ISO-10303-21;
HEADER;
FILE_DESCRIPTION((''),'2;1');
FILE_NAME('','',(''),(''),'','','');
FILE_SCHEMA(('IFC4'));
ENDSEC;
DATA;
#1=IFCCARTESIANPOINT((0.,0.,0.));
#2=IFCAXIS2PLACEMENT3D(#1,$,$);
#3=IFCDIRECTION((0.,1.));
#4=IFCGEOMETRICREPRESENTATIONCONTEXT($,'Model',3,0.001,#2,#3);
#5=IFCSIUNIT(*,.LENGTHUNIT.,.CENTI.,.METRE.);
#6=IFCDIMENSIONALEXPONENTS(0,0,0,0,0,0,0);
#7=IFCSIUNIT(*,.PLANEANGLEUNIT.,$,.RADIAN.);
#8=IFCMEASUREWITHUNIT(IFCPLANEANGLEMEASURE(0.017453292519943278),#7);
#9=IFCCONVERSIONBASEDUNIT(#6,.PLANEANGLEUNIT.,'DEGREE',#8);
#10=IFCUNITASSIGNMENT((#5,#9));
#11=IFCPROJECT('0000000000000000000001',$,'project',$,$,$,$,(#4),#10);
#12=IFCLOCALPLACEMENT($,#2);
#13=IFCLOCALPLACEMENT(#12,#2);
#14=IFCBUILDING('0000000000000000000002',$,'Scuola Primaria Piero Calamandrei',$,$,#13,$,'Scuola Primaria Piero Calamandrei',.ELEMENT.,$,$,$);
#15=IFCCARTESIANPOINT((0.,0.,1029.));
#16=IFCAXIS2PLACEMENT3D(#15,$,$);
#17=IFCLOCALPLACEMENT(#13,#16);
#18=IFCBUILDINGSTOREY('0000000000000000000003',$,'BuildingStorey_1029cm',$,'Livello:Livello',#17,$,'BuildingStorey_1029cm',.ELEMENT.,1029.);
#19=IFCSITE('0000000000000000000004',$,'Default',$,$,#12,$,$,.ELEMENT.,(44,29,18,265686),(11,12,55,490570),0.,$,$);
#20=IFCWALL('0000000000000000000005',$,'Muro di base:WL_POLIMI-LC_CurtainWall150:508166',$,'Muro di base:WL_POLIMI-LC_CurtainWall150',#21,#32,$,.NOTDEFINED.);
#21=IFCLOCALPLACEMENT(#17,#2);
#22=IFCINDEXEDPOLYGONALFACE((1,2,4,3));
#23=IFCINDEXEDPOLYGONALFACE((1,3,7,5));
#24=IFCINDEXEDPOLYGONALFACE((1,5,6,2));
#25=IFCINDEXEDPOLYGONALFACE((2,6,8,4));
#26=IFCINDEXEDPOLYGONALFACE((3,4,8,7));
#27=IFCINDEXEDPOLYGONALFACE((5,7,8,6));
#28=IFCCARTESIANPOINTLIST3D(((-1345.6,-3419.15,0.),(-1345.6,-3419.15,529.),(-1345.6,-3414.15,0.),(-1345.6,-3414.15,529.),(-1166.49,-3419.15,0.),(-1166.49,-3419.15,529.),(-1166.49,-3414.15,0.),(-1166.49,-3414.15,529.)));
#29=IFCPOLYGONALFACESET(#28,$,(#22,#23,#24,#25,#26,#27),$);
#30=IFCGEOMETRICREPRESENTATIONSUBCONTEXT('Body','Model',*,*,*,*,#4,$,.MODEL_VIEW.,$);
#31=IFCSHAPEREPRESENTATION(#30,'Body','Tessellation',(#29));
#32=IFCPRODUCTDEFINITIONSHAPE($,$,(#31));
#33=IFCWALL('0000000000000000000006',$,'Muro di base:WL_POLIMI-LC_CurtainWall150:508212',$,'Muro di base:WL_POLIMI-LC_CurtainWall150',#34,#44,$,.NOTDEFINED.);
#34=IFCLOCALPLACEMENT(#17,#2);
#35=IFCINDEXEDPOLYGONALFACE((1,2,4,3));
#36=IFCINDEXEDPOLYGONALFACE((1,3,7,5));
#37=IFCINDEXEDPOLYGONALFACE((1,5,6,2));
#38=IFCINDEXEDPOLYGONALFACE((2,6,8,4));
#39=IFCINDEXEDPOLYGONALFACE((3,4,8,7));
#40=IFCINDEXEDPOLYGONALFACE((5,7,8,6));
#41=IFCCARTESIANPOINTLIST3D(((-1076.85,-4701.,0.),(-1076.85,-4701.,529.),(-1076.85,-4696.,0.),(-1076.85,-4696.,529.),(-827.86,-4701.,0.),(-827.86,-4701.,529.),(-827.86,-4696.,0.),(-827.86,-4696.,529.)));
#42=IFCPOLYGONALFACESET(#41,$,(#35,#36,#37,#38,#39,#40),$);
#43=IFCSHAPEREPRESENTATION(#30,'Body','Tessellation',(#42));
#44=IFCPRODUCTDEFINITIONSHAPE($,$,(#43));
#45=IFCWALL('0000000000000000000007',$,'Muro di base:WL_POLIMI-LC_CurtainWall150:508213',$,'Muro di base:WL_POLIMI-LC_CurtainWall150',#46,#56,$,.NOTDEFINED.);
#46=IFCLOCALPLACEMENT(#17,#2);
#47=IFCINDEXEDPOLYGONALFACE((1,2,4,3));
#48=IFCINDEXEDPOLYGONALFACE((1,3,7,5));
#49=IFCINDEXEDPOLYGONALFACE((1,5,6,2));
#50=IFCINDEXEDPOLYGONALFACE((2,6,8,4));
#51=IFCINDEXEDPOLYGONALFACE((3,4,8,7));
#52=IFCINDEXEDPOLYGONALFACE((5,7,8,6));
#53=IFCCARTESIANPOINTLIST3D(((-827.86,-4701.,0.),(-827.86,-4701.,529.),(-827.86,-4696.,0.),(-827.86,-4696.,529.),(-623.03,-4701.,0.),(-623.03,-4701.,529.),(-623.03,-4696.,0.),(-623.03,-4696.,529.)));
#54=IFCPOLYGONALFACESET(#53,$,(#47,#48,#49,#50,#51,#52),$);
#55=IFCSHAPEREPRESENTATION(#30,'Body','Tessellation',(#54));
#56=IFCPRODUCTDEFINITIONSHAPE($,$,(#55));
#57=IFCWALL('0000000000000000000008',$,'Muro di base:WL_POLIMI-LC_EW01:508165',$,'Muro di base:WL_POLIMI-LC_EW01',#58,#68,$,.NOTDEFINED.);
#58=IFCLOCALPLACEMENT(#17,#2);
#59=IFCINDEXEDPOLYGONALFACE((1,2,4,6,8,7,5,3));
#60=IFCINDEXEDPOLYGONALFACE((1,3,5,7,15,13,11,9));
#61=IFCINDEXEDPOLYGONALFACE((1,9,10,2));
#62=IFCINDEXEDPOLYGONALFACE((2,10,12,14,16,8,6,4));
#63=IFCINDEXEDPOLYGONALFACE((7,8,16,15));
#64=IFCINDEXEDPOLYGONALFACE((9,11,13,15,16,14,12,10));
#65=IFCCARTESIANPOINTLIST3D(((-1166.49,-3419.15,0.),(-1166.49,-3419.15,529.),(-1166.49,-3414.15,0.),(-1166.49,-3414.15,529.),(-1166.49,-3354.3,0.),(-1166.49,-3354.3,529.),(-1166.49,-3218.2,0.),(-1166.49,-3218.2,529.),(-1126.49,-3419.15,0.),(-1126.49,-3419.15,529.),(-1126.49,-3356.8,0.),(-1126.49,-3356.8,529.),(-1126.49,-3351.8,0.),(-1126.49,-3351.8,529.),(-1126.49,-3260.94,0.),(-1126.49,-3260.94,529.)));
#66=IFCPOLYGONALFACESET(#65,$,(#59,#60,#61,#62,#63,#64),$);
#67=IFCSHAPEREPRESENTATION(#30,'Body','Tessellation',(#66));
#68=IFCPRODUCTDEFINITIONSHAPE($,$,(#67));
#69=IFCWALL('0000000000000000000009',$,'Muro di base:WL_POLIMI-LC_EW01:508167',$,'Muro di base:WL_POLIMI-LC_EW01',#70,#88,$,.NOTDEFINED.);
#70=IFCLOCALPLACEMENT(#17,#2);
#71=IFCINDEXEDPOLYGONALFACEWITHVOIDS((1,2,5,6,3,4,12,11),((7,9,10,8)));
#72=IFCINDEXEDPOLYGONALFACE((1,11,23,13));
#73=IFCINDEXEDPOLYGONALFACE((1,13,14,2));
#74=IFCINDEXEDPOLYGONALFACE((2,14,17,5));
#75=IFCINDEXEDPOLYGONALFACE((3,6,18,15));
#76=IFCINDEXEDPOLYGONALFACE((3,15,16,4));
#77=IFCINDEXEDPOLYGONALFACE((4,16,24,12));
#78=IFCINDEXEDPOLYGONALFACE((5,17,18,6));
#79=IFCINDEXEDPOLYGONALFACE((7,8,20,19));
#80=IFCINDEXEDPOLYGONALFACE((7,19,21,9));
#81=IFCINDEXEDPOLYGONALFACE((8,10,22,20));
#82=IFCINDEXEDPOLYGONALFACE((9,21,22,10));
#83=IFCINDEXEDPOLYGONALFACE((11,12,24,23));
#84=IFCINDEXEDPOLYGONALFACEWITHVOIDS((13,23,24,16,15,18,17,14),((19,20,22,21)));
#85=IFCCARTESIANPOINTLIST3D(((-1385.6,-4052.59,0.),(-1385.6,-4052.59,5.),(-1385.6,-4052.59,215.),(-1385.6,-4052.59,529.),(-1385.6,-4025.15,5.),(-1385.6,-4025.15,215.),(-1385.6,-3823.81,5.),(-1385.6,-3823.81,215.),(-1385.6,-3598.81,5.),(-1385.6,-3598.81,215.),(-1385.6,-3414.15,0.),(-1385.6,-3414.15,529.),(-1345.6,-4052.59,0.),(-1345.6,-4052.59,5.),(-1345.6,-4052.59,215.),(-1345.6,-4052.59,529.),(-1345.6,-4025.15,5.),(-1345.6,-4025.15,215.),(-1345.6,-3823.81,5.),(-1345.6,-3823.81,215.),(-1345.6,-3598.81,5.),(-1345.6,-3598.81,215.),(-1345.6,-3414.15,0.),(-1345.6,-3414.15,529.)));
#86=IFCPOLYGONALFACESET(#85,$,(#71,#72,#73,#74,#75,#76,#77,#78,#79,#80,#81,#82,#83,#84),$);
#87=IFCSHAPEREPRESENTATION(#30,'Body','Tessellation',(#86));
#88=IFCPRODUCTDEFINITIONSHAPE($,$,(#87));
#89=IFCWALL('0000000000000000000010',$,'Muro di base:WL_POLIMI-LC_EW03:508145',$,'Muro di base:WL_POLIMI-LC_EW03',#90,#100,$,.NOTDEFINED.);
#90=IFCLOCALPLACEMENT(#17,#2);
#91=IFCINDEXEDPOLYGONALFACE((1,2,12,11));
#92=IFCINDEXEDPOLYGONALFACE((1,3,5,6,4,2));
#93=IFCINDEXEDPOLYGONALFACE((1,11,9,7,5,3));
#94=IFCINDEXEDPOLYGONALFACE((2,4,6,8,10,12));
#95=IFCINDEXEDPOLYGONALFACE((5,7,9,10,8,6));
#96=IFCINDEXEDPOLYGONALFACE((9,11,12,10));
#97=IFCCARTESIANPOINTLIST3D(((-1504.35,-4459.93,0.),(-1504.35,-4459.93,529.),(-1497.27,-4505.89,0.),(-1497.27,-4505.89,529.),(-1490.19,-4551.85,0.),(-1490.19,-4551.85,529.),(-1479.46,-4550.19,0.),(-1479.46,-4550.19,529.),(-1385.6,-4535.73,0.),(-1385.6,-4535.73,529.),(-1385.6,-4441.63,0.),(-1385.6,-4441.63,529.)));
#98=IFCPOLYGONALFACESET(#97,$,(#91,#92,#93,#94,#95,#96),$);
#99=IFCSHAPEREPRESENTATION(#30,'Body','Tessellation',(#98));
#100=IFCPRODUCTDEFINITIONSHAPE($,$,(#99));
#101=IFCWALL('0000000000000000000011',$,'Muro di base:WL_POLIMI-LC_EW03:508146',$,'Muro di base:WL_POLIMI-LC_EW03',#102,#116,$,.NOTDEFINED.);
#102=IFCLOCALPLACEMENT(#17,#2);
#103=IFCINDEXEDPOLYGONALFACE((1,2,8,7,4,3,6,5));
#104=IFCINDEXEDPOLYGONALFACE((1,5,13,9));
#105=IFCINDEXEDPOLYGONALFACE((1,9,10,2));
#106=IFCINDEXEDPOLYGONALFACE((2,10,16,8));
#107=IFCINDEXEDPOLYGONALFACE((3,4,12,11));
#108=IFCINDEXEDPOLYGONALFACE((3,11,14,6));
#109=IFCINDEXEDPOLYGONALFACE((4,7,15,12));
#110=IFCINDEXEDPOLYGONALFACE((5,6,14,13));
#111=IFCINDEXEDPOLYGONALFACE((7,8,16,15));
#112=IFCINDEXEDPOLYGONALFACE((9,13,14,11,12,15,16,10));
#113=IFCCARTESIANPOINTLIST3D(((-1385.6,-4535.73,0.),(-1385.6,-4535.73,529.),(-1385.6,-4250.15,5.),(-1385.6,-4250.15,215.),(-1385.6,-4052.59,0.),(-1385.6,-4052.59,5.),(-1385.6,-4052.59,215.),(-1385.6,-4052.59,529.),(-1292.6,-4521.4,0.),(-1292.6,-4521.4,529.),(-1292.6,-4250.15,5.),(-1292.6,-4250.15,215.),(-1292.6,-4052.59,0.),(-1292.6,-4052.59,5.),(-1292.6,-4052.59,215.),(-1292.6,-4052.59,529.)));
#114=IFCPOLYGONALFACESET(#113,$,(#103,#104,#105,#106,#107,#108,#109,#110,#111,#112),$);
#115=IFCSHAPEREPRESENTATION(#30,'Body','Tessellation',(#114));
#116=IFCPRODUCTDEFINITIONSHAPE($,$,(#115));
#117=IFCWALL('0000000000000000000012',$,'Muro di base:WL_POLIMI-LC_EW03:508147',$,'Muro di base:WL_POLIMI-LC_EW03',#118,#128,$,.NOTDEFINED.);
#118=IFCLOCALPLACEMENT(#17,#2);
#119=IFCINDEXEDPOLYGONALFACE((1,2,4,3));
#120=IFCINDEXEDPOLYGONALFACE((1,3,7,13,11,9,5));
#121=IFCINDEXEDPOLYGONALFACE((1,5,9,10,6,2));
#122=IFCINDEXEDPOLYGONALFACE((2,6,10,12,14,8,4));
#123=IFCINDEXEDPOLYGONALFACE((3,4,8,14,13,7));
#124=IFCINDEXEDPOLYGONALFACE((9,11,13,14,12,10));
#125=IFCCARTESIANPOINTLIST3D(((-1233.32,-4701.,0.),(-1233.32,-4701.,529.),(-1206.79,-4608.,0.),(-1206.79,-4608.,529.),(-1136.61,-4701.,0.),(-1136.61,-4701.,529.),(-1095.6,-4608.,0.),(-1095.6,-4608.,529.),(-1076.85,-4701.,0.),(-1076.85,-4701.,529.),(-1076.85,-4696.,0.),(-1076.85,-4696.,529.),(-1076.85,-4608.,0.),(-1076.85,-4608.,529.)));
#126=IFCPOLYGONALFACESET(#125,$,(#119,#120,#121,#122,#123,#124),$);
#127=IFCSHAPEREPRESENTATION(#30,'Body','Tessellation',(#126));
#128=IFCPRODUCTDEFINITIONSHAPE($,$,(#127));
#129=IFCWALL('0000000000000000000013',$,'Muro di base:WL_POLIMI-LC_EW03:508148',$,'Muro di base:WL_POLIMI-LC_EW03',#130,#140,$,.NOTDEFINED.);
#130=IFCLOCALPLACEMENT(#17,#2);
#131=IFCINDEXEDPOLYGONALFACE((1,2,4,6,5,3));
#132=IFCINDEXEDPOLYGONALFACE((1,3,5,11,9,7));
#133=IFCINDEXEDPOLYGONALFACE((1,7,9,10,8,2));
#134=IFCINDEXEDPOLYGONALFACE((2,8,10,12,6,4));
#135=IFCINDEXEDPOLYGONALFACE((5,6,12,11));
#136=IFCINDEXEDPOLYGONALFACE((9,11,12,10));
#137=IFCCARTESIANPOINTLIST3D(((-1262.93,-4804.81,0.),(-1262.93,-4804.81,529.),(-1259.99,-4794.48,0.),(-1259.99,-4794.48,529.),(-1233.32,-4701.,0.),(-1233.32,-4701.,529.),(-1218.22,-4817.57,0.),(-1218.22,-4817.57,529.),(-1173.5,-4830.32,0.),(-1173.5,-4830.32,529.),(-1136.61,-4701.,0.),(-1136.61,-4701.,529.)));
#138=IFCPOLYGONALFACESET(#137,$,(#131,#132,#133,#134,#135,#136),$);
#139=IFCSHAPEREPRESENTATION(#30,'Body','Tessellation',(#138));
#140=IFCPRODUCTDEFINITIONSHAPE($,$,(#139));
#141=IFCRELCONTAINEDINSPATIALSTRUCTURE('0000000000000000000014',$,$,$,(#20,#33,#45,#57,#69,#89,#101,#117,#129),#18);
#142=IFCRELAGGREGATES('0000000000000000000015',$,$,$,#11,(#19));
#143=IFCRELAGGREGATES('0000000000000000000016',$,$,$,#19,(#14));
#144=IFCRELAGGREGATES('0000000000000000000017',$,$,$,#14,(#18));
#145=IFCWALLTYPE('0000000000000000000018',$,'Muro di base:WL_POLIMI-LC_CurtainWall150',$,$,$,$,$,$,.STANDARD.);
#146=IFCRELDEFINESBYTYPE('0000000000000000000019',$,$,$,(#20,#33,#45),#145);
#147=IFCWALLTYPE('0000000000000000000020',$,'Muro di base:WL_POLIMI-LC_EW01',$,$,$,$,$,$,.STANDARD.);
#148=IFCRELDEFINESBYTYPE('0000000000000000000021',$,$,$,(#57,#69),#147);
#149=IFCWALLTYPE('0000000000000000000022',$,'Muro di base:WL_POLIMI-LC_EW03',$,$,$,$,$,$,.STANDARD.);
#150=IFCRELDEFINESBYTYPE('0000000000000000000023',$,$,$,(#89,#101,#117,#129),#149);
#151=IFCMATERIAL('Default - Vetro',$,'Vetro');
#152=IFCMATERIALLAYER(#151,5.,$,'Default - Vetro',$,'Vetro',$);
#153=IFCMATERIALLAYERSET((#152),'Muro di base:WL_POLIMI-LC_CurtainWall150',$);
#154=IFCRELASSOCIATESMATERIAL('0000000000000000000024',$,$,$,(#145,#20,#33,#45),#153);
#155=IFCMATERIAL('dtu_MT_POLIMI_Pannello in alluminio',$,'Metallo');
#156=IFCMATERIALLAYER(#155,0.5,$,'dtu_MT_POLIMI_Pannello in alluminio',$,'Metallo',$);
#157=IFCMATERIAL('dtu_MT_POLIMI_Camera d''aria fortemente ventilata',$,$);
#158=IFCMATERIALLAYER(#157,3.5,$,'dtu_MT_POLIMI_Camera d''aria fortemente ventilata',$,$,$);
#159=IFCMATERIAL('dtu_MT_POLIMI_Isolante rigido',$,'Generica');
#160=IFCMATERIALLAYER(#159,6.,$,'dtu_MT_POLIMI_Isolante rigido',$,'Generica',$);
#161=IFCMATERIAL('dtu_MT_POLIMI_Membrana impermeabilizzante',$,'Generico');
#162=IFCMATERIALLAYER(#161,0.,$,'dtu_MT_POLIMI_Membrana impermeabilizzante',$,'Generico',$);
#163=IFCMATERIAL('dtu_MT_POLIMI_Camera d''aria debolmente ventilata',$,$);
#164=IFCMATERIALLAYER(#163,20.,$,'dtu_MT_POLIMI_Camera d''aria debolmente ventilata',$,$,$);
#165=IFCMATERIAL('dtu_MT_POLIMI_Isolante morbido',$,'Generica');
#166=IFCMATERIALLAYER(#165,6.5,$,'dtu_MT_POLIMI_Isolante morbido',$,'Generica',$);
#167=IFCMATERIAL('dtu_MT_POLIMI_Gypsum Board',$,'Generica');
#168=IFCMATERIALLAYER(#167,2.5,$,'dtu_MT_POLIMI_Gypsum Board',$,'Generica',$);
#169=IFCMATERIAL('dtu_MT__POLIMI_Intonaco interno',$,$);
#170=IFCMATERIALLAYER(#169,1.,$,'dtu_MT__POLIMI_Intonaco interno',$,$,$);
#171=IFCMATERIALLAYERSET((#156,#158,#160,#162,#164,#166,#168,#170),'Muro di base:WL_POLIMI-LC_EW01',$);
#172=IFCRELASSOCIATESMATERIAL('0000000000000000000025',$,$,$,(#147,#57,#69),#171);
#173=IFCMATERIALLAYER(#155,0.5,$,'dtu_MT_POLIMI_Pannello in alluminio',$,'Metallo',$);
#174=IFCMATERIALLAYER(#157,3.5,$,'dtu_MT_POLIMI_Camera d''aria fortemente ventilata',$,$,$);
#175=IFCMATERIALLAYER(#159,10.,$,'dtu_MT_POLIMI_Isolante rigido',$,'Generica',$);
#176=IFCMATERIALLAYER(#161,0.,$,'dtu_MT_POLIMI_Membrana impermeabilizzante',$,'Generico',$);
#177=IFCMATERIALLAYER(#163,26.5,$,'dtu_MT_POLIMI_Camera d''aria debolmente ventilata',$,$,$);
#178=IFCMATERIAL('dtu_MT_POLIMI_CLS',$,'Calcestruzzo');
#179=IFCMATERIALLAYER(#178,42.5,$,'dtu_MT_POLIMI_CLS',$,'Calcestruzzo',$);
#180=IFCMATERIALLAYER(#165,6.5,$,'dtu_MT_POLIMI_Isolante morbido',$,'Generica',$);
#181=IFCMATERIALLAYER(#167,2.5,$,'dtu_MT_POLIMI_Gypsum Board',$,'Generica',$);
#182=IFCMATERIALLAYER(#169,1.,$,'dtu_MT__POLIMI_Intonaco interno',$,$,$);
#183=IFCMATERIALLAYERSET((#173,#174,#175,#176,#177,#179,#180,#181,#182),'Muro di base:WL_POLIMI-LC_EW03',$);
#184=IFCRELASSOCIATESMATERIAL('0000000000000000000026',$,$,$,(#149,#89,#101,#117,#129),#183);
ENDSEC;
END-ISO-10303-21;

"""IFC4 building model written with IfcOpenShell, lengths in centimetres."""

from ifc_helpers import new_model, entity, si_unit, converted_unit, direction, frame, frame_2d, origin, place, context, subcontext, project, spatial, polyline, rectangle, outline, extrude, material, layer, layer_set, layer_usage, type_object, element, save


model = new_model("IFC4")

# Units and contexts
model_context = context("Model", 3, precision=0.001, world=origin(), true_north=direction((0.0, 1.0)))
body_context = subcontext(model_context, "Body", "Model", "MODEL_VIEW")
ifc_project = project(units=[si_unit("LENGTHUNIT", "METRE", prefix="CENTI"), converted_unit("PLANEANGLEUNIT", "DEGREE", entity("IfcPlaneAngleMeasure", 0.017453292519943278), si_unit("PLANEANGLEUNIT", "RADIAN"), dimensions=[0, 0, 0, 0, 0, 0, 0])], contexts=[model_context])

# Site, building, storey
site_placement = place(None, origin())
site = spatial("IfcSite", under=ifc_project, at=site_placement, Name="Default", CompositionType="ELEMENT", RefLatitude=(44, 29, 18, 265686), RefLongitude=(11, 12, 55, 490570), RefElevation=0.0)
building_placement = place(site_placement, origin())
building = spatial("IfcBuilding", under=site, at=building_placement, Name="Scuola Primaria Piero Calamandrei", LongName="Scuola Primaria Piero Calamandrei", CompositionType="ELEMENT")
storey_placement = place(building_placement, frame((0.0, 0.0, 1029.0)))
storey = spatial("IfcBuildingStorey", under=building, at=storey_placement, Name="BuildingStorey_1029cm", ObjectType="Livello:Livello", LongName="BuildingStorey_1029cm", CompositionType="ELEMENT", Elevation=1029.0)

# Walls
ifc_material_1 = material(Name="Default - Vetro", Category="Vetro")
ifc_layer_1 = layer(ifc_material_1, 5.0, Name="Default - Vetro", Category="Vetro")
ifc_layer_set_1 = layer_set([ifc_layer_1], Name="Muro di base:WL_POLIMI-LC_CurtainWall150")
ifc_layer_usage_1 = layer_usage(ifc_layer_set_1, "AXIS2", "NEGATIVE", 2.5)
wall_type_1 = type_object("IfcWallType", Name="Muro di base:WL_POLIMI-LC_CurtainWall150", PredefinedType="STANDARD", material=ifc_layer_set_1)
wall_1_placement = place(storey_placement, frame((-1345.6, -3416.65, 0.0)))
element("IfcWall", 1, at=wall_1_placement, inside=storey, type_object=wall_type_1, material=ifc_layer_usage_1, Name="Muro di base:WL_POLIMI-LC_CurtainWall150:508166", ObjectType="Muro di base:WL_POLIMI-LC_CurtainWall150", PredefinedType="NOTDEFINED", context=body_context, shape_type="SweptSolid", body=[
    extrude(rectangle(XDim=179.11, YDim=5.0, at=frame_2d((89.56, 0.0), x_axis=(-1.0, 0.0))), origin(), (0.0, 0.0, 1.0), 529.0),
])
ifc_layer_usage_2 = layer_usage(ifc_layer_set_1, "AXIS2", "NEGATIVE", 2.5)
wall_2_placement = place(storey_placement, frame((-827.86, -4698.5, 0.0), z_axis=(0.0, 0.0, 1.0), x_axis=(-1.0, 0.0, 0.0)))
element("IfcWall", 2, at=wall_2_placement, inside=storey, type_object=wall_type_1, material=ifc_layer_usage_2, Name="Muro di base:WL_POLIMI-LC_CurtainWall150:508212", ObjectType="Muro di base:WL_POLIMI-LC_CurtainWall150", PredefinedType="NOTDEFINED", context=body_context, shape_type="SweptSolid", body=[
    extrude(rectangle(XDim=248.99, YDim=5.0, at=frame_2d((124.5, 0.0), x_axis=(-1.0, 0.0))), origin(), (0.0, 0.0, 1.0), 529.0),
])
ifc_layer_usage_3 = layer_usage(ifc_layer_set_1, "AXIS2", "NEGATIVE", 2.5)
wall_3_placement = place(storey_placement, frame((-623.03, -4698.5, 0.0), z_axis=(0.0, 0.0, 1.0), x_axis=(-1.0, 0.0, 0.0)))
element("IfcWall", 3, at=wall_3_placement, inside=storey, type_object=wall_type_1, material=ifc_layer_usage_3, Name="Muro di base:WL_POLIMI-LC_CurtainWall150:508213", ObjectType="Muro di base:WL_POLIMI-LC_CurtainWall150", PredefinedType="NOTDEFINED", context=body_context, shape_type="SweptSolid", body=[
    extrude(rectangle(XDim=204.83, YDim=5.0, at=frame_2d((102.41, 0.0), x_axis=(-1.0, 0.0))), origin(), (0.0, 0.0, 1.0), 529.0),
])
ifc_material_2 = material(Name="dtu_MT_POLIMI_Pannello in alluminio", Category="Metallo")
ifc_layer_2 = layer(ifc_material_2, 0.5, Name="dtu_MT_POLIMI_Pannello in alluminio", Category="Metallo")
ifc_material_3 = material(Name="dtu_MT_POLIMI_Camera d'aria fortemente ventilata")
ifc_layer_3 = layer(ifc_material_3, 3.5, Name="dtu_MT_POLIMI_Camera d'aria fortemente ventilata")
ifc_material_4 = material(Name="dtu_MT_POLIMI_Isolante rigido", Category="Generica")
ifc_layer_4 = layer(ifc_material_4, 6.0, Name="dtu_MT_POLIMI_Isolante rigido", Category="Generica")
ifc_material_5 = material(Name="dtu_MT_POLIMI_Membrana impermeabilizzante", Category="Generico")
ifc_layer_5 = layer(ifc_material_5, 0.0, Name="dtu_MT_POLIMI_Membrana impermeabilizzante", Category="Generico")
ifc_material_6 = material(Name="dtu_MT_POLIMI_Camera d'aria debolmente ventilata")
ifc_layer_6 = layer(ifc_material_6, 20.0, Name="dtu_MT_POLIMI_Camera d'aria debolmente ventilata")
ifc_material_7 = material(Name="dtu_MT_POLIMI_Isolante morbido", Category="Generica")
ifc_layer_7 = layer(ifc_material_7, 6.5, Name="dtu_MT_POLIMI_Isolante morbido", Category="Generica")
ifc_material_8 = material(Name="dtu_MT_POLIMI_Gypsum Board", Category="Generica")
ifc_layer_8 = layer(ifc_material_8, 2.5, Name="dtu_MT_POLIMI_Gypsum Board", Category="Generica")
ifc_material_9 = material(Name="dtu_MT__POLIMI_Intonaco interno")
ifc_layer_9 = layer(ifc_material_9, 1.0, Name="dtu_MT__POLIMI_Intonaco interno")
ifc_layer_set_2 = layer_set([ifc_layer_2, ifc_layer_3, ifc_layer_4, ifc_layer_5, ifc_layer_6, ifc_layer_7, ifc_layer_8, ifc_layer_9], Name="Muro di base:WL_POLIMI-LC_EW01")
ifc_layer_usage_4 = layer_usage(ifc_layer_set_2, "AXIS2", "NEGATIVE", 20.0)
wall_type_2 = type_object("IfcWallType", Name="Muro di base:WL_POLIMI-LC_EW01", PredefinedType="STANDARD", material=ifc_layer_set_2)
wall_4_placement = place(storey_placement, frame((-1146.49, -3419.15, 0.0), z_axis=(0.0, 0.0, 1.0), x_axis=(0.0, 1.0, 0.0)))
element("IfcWall", 4, at=wall_4_placement, inside=storey, type_object=wall_type_2, material=ifc_layer_usage_4, Name="Muro di base:WL_POLIMI-LC_EW01:508165", ObjectType="Muro di base:WL_POLIMI-LC_EW01", PredefinedType="NOTDEFINED", context=body_context, shape_type="SweptSolid", body=[
    extrude(outline(polyline([(158.21, -20.0), (200.95, 20.0), (64.85, 20.0), (5.0, 20.0), (0.0, 20.0), (0.0, -20.0), (62.35, -20.0), (67.35, -20.0), (158.21, -20.0)])), origin(), (0.0, 0.0, 1.0), 529.0),
])

# Wall, openings
ifc_layer_usage_5 = layer_usage(ifc_layer_set_2, "AXIS2", "NEGATIVE", 20.0)
wall_5_placement = place(storey_placement, frame((-1365.6, -4052.59, 0.0), z_axis=(0.0, 0.0, 1.0), x_axis=(0.0, 1.0, 0.0)))
wall_5 = element("IfcWall", 5, at=wall_5_placement, inside=storey, type_object=wall_type_2, material=ifc_layer_usage_5, Name="Muro di base:WL_POLIMI-LC_EW01:508167", ObjectType="Muro di base:WL_POLIMI-LC_EW01", PredefinedType="NOTDEFINED", context=body_context, shape_type="SweptSolid", body=[
    extrude(rectangle(XDim=638.44, YDim=40.0, at=frame_2d((319.22, 0.0), x_axis=(-1.0, 0.0))), origin(), (0.0, 0.0, 1.0), 529.0),
])
opening_1_placement = place(wall_5_placement, frame((-197.56, -20.0, 5.0)))
element("IfcOpeningElement", 6, at=opening_1_placement, cuts=wall_5, PredefinedType="OPENING", context=body_context, shape_type="SweptSolid", body=[
    extrude(rectangle(XDim=210.0, YDim=225.0, at=frame_2d((105.0, 112.5), x_axis=(-1.0, 0.0))), frame((0.0, 0.0, 0.0), z_axis=(0.0, 1.0, 0.0), x_axis=(0.0, 0.0, 1.0)), (0.0, 0.0, 1.0), 40.0),
])
opening_2_placement = place(wall_5_placement, frame((228.77, -20.0, 5.0)))
element("IfcOpeningElement", 7, at=opening_2_placement, cuts=wall_5, PredefinedType="OPENING", context=body_context, shape_type="SweptSolid", body=[
    extrude(rectangle(XDim=210.0, YDim=225.0, at=frame_2d((105.0, 112.5), x_axis=(-1.0, 0.0))), frame((0.0, 0.0, 0.0), z_axis=(0.0, 1.0, 0.0), x_axis=(0.0, 0.0, 1.0)), (0.0, 0.0, 1.0), 40.0),
])

# Wall
ifc_layer_10 = layer(ifc_material_2, 0.5, Name="dtu_MT_POLIMI_Pannello in alluminio", Category="Metallo")
ifc_layer_11 = layer(ifc_material_3, 3.5, Name="dtu_MT_POLIMI_Camera d'aria fortemente ventilata")
ifc_layer_12 = layer(ifc_material_4, 10.0, Name="dtu_MT_POLIMI_Isolante rigido", Category="Generica")
ifc_layer_13 = layer(ifc_material_5, 0.0, Name="dtu_MT_POLIMI_Membrana impermeabilizzante", Category="Generico")
ifc_layer_14 = layer(ifc_material_6, 26.5, Name="dtu_MT_POLIMI_Camera d'aria debolmente ventilata")
ifc_material_10 = material(Name="dtu_MT_POLIMI_CLS", Category="Calcestruzzo")
ifc_layer_15 = layer(ifc_material_10, 42.5, Name="dtu_MT_POLIMI_CLS", Category="Calcestruzzo")
ifc_layer_16 = layer(ifc_material_7, 6.5, Name="dtu_MT_POLIMI_Isolante morbido", Category="Generica")
ifc_layer_17 = layer(ifc_material_8, 2.5, Name="dtu_MT_POLIMI_Gypsum Board", Category="Generica")
ifc_layer_18 = layer(ifc_material_9, 1.0, Name="dtu_MT__POLIMI_Intonaco interno")
ifc_layer_set_3 = layer_set([ifc_layer_10, ifc_layer_11, ifc_layer_12, ifc_layer_13, ifc_layer_14, ifc_layer_15, ifc_layer_16, ifc_layer_17, ifc_layer_18], Name="Muro di base:WL_POLIMI-LC_EW03")
wall_type_3 = type_object("IfcWallType", Name="Muro di base:WL_POLIMI-LC_EW03", PredefinedType="STANDARD", material=ifc_layer_set_3)
ifc_layer_usage_6 = layer_usage(ifc_layer_set_3, "AXIS2", "NEGATIVE", 46.5)
wall_6_placement = place(storey_placement, frame((-1497.27, -4505.89, 0.0), z_axis=(0.0, 0.0, 1.0), x_axis=(0.988335, 0.152294, 0.0)))
element("IfcWall", 8, at=wall_6_placement, inside=storey, type_object=wall_type_3, material=ifc_layer_usage_6, Name="Muro di base:WL_POLIMI-LC_EW03:508145", ObjectType="Muro di base:WL_POLIMI-LC_EW03", PredefinedType="NOTDEFINED", context=body_context, shape_type="SweptSolid", body=[
    extrude(outline(polyline([(105.82, -46.5), (120.15, 46.5), (0.0, 46.5), (0.0, 0.0), (0.0, -46.5), (10.85, -46.5), (105.82, -46.5)])), origin(), (0.0, 0.0, 1.0), 529.0),
])

# Wall, opening
ifc_layer_usage_7 = layer_usage(ifc_layer_set_3, "AXIS2", "NEGATIVE", 46.5)
wall_7_placement = place(storey_placement, frame((-1339.1, -4535.73, 0.0), z_axis=(0.0, 0.0, 1.0), x_axis=(0.0, 1.0, 0.0)))
wall_7 = element("IfcWall", 9, at=wall_7_placement, inside=storey, type_object=wall_type_3, material=ifc_layer_usage_7, Name="Muro di base:WL_POLIMI-LC_EW03:508146", ObjectType="Muro di base:WL_POLIMI-LC_EW03", PredefinedType="NOTDEFINED", context=body_context, shape_type="SweptSolid", body=[
    extrude(outline(polyline([(483.14, -46.5), (483.14, 6.5), (483.14, 46.5), (94.1, 46.5), (0.0, 46.5), (14.33, -46.5), (472.39, -46.5), (483.14, -46.5)])), origin(), (0.0, 0.0, 1.0), 529.0),
])
opening_3_placement = place(wall_7_placement, frame((4535.73, -1339.1, 5.0)))
element("IfcOpeningElement", 10, at=opening_3_placement, cuts=wall_7, PredefinedType="OPENING", context=body_context, shape_type="SweptSolid", body=[
    extrude(rectangle(XDim=210.0, YDim=225.0, at=frame_2d((0.0, 0.0), x_axis=(0.0, 1.0))), frame((-4137.65, 1233.2, 105.0), z_axis=(0.0, 1.0, 0.0), x_axis=(1.0, 0.0, 0.0)), (0.0, 0.0, 1.0), 304.8),
])

# Walls
ifc_layer_usage_8 = layer_usage(ifc_layer_set_3, "AXIS2", "NEGATIVE", 46.5)
wall_8_placement = place(storey_placement, frame((-1076.85, -4654.5, 0.0), z_axis=(0.0, 0.0, 1.0), x_axis=(-1.0, 0.0, 0.0)))
element("IfcWall", 11, at=wall_8_placement, inside=storey, type_object=wall_type_3, material=ifc_layer_usage_8, Name="Muro di base:WL_POLIMI-LC_EW03:508147", ObjectType="Muro di base:WL_POLIMI-LC_EW03", PredefinedType="NOTDEFINED", context=body_context, shape_type="SweptSolid", body=[
    extrude(outline(polyline([(129.94, -46.5), (156.47, 46.5), (59.76, 46.5), (0.0, 46.5), (0.0, 41.5), (0.0, -46.5), (18.75, -46.5), (129.94, -46.5)])), origin(), (0.0, 0.0, 1.0), 529.0),
])
ifc_layer_usage_9 = layer_usage(ifc_layer_set_3, "AXIS2", "NEGATIVE", 46.5)
wall_9_placement = place(storey_placement, frame((-1181.33, -4688.24, 0.0), z_axis=(0.0, 0.0, 1.0), x_axis=(-0.274316, -0.96164, 0.0)))
element("IfcWall", 12, at=wall_9_placement, inside=storey, type_object=wall_type_3, material=ifc_layer_usage_9, Name="Muro di base:WL_POLIMI-LC_EW03:508148", ObjectType="Muro di base:WL_POLIMI-LC_EW03", PredefinedType="NOTDEFINED", context=body_context, shape_type="SweptSolid", body=[
    extrude(outline(polyline([(134.48, -46.5), (134.48, 0.0), (134.48, 46.5), (0.0, 46.5), (26.53, -46.5), (123.74, -46.5), (134.48, -46.5)])), origin(), (0.0, 0.0, 1.0), 529.0),
])

save(model, "model.ifc")
